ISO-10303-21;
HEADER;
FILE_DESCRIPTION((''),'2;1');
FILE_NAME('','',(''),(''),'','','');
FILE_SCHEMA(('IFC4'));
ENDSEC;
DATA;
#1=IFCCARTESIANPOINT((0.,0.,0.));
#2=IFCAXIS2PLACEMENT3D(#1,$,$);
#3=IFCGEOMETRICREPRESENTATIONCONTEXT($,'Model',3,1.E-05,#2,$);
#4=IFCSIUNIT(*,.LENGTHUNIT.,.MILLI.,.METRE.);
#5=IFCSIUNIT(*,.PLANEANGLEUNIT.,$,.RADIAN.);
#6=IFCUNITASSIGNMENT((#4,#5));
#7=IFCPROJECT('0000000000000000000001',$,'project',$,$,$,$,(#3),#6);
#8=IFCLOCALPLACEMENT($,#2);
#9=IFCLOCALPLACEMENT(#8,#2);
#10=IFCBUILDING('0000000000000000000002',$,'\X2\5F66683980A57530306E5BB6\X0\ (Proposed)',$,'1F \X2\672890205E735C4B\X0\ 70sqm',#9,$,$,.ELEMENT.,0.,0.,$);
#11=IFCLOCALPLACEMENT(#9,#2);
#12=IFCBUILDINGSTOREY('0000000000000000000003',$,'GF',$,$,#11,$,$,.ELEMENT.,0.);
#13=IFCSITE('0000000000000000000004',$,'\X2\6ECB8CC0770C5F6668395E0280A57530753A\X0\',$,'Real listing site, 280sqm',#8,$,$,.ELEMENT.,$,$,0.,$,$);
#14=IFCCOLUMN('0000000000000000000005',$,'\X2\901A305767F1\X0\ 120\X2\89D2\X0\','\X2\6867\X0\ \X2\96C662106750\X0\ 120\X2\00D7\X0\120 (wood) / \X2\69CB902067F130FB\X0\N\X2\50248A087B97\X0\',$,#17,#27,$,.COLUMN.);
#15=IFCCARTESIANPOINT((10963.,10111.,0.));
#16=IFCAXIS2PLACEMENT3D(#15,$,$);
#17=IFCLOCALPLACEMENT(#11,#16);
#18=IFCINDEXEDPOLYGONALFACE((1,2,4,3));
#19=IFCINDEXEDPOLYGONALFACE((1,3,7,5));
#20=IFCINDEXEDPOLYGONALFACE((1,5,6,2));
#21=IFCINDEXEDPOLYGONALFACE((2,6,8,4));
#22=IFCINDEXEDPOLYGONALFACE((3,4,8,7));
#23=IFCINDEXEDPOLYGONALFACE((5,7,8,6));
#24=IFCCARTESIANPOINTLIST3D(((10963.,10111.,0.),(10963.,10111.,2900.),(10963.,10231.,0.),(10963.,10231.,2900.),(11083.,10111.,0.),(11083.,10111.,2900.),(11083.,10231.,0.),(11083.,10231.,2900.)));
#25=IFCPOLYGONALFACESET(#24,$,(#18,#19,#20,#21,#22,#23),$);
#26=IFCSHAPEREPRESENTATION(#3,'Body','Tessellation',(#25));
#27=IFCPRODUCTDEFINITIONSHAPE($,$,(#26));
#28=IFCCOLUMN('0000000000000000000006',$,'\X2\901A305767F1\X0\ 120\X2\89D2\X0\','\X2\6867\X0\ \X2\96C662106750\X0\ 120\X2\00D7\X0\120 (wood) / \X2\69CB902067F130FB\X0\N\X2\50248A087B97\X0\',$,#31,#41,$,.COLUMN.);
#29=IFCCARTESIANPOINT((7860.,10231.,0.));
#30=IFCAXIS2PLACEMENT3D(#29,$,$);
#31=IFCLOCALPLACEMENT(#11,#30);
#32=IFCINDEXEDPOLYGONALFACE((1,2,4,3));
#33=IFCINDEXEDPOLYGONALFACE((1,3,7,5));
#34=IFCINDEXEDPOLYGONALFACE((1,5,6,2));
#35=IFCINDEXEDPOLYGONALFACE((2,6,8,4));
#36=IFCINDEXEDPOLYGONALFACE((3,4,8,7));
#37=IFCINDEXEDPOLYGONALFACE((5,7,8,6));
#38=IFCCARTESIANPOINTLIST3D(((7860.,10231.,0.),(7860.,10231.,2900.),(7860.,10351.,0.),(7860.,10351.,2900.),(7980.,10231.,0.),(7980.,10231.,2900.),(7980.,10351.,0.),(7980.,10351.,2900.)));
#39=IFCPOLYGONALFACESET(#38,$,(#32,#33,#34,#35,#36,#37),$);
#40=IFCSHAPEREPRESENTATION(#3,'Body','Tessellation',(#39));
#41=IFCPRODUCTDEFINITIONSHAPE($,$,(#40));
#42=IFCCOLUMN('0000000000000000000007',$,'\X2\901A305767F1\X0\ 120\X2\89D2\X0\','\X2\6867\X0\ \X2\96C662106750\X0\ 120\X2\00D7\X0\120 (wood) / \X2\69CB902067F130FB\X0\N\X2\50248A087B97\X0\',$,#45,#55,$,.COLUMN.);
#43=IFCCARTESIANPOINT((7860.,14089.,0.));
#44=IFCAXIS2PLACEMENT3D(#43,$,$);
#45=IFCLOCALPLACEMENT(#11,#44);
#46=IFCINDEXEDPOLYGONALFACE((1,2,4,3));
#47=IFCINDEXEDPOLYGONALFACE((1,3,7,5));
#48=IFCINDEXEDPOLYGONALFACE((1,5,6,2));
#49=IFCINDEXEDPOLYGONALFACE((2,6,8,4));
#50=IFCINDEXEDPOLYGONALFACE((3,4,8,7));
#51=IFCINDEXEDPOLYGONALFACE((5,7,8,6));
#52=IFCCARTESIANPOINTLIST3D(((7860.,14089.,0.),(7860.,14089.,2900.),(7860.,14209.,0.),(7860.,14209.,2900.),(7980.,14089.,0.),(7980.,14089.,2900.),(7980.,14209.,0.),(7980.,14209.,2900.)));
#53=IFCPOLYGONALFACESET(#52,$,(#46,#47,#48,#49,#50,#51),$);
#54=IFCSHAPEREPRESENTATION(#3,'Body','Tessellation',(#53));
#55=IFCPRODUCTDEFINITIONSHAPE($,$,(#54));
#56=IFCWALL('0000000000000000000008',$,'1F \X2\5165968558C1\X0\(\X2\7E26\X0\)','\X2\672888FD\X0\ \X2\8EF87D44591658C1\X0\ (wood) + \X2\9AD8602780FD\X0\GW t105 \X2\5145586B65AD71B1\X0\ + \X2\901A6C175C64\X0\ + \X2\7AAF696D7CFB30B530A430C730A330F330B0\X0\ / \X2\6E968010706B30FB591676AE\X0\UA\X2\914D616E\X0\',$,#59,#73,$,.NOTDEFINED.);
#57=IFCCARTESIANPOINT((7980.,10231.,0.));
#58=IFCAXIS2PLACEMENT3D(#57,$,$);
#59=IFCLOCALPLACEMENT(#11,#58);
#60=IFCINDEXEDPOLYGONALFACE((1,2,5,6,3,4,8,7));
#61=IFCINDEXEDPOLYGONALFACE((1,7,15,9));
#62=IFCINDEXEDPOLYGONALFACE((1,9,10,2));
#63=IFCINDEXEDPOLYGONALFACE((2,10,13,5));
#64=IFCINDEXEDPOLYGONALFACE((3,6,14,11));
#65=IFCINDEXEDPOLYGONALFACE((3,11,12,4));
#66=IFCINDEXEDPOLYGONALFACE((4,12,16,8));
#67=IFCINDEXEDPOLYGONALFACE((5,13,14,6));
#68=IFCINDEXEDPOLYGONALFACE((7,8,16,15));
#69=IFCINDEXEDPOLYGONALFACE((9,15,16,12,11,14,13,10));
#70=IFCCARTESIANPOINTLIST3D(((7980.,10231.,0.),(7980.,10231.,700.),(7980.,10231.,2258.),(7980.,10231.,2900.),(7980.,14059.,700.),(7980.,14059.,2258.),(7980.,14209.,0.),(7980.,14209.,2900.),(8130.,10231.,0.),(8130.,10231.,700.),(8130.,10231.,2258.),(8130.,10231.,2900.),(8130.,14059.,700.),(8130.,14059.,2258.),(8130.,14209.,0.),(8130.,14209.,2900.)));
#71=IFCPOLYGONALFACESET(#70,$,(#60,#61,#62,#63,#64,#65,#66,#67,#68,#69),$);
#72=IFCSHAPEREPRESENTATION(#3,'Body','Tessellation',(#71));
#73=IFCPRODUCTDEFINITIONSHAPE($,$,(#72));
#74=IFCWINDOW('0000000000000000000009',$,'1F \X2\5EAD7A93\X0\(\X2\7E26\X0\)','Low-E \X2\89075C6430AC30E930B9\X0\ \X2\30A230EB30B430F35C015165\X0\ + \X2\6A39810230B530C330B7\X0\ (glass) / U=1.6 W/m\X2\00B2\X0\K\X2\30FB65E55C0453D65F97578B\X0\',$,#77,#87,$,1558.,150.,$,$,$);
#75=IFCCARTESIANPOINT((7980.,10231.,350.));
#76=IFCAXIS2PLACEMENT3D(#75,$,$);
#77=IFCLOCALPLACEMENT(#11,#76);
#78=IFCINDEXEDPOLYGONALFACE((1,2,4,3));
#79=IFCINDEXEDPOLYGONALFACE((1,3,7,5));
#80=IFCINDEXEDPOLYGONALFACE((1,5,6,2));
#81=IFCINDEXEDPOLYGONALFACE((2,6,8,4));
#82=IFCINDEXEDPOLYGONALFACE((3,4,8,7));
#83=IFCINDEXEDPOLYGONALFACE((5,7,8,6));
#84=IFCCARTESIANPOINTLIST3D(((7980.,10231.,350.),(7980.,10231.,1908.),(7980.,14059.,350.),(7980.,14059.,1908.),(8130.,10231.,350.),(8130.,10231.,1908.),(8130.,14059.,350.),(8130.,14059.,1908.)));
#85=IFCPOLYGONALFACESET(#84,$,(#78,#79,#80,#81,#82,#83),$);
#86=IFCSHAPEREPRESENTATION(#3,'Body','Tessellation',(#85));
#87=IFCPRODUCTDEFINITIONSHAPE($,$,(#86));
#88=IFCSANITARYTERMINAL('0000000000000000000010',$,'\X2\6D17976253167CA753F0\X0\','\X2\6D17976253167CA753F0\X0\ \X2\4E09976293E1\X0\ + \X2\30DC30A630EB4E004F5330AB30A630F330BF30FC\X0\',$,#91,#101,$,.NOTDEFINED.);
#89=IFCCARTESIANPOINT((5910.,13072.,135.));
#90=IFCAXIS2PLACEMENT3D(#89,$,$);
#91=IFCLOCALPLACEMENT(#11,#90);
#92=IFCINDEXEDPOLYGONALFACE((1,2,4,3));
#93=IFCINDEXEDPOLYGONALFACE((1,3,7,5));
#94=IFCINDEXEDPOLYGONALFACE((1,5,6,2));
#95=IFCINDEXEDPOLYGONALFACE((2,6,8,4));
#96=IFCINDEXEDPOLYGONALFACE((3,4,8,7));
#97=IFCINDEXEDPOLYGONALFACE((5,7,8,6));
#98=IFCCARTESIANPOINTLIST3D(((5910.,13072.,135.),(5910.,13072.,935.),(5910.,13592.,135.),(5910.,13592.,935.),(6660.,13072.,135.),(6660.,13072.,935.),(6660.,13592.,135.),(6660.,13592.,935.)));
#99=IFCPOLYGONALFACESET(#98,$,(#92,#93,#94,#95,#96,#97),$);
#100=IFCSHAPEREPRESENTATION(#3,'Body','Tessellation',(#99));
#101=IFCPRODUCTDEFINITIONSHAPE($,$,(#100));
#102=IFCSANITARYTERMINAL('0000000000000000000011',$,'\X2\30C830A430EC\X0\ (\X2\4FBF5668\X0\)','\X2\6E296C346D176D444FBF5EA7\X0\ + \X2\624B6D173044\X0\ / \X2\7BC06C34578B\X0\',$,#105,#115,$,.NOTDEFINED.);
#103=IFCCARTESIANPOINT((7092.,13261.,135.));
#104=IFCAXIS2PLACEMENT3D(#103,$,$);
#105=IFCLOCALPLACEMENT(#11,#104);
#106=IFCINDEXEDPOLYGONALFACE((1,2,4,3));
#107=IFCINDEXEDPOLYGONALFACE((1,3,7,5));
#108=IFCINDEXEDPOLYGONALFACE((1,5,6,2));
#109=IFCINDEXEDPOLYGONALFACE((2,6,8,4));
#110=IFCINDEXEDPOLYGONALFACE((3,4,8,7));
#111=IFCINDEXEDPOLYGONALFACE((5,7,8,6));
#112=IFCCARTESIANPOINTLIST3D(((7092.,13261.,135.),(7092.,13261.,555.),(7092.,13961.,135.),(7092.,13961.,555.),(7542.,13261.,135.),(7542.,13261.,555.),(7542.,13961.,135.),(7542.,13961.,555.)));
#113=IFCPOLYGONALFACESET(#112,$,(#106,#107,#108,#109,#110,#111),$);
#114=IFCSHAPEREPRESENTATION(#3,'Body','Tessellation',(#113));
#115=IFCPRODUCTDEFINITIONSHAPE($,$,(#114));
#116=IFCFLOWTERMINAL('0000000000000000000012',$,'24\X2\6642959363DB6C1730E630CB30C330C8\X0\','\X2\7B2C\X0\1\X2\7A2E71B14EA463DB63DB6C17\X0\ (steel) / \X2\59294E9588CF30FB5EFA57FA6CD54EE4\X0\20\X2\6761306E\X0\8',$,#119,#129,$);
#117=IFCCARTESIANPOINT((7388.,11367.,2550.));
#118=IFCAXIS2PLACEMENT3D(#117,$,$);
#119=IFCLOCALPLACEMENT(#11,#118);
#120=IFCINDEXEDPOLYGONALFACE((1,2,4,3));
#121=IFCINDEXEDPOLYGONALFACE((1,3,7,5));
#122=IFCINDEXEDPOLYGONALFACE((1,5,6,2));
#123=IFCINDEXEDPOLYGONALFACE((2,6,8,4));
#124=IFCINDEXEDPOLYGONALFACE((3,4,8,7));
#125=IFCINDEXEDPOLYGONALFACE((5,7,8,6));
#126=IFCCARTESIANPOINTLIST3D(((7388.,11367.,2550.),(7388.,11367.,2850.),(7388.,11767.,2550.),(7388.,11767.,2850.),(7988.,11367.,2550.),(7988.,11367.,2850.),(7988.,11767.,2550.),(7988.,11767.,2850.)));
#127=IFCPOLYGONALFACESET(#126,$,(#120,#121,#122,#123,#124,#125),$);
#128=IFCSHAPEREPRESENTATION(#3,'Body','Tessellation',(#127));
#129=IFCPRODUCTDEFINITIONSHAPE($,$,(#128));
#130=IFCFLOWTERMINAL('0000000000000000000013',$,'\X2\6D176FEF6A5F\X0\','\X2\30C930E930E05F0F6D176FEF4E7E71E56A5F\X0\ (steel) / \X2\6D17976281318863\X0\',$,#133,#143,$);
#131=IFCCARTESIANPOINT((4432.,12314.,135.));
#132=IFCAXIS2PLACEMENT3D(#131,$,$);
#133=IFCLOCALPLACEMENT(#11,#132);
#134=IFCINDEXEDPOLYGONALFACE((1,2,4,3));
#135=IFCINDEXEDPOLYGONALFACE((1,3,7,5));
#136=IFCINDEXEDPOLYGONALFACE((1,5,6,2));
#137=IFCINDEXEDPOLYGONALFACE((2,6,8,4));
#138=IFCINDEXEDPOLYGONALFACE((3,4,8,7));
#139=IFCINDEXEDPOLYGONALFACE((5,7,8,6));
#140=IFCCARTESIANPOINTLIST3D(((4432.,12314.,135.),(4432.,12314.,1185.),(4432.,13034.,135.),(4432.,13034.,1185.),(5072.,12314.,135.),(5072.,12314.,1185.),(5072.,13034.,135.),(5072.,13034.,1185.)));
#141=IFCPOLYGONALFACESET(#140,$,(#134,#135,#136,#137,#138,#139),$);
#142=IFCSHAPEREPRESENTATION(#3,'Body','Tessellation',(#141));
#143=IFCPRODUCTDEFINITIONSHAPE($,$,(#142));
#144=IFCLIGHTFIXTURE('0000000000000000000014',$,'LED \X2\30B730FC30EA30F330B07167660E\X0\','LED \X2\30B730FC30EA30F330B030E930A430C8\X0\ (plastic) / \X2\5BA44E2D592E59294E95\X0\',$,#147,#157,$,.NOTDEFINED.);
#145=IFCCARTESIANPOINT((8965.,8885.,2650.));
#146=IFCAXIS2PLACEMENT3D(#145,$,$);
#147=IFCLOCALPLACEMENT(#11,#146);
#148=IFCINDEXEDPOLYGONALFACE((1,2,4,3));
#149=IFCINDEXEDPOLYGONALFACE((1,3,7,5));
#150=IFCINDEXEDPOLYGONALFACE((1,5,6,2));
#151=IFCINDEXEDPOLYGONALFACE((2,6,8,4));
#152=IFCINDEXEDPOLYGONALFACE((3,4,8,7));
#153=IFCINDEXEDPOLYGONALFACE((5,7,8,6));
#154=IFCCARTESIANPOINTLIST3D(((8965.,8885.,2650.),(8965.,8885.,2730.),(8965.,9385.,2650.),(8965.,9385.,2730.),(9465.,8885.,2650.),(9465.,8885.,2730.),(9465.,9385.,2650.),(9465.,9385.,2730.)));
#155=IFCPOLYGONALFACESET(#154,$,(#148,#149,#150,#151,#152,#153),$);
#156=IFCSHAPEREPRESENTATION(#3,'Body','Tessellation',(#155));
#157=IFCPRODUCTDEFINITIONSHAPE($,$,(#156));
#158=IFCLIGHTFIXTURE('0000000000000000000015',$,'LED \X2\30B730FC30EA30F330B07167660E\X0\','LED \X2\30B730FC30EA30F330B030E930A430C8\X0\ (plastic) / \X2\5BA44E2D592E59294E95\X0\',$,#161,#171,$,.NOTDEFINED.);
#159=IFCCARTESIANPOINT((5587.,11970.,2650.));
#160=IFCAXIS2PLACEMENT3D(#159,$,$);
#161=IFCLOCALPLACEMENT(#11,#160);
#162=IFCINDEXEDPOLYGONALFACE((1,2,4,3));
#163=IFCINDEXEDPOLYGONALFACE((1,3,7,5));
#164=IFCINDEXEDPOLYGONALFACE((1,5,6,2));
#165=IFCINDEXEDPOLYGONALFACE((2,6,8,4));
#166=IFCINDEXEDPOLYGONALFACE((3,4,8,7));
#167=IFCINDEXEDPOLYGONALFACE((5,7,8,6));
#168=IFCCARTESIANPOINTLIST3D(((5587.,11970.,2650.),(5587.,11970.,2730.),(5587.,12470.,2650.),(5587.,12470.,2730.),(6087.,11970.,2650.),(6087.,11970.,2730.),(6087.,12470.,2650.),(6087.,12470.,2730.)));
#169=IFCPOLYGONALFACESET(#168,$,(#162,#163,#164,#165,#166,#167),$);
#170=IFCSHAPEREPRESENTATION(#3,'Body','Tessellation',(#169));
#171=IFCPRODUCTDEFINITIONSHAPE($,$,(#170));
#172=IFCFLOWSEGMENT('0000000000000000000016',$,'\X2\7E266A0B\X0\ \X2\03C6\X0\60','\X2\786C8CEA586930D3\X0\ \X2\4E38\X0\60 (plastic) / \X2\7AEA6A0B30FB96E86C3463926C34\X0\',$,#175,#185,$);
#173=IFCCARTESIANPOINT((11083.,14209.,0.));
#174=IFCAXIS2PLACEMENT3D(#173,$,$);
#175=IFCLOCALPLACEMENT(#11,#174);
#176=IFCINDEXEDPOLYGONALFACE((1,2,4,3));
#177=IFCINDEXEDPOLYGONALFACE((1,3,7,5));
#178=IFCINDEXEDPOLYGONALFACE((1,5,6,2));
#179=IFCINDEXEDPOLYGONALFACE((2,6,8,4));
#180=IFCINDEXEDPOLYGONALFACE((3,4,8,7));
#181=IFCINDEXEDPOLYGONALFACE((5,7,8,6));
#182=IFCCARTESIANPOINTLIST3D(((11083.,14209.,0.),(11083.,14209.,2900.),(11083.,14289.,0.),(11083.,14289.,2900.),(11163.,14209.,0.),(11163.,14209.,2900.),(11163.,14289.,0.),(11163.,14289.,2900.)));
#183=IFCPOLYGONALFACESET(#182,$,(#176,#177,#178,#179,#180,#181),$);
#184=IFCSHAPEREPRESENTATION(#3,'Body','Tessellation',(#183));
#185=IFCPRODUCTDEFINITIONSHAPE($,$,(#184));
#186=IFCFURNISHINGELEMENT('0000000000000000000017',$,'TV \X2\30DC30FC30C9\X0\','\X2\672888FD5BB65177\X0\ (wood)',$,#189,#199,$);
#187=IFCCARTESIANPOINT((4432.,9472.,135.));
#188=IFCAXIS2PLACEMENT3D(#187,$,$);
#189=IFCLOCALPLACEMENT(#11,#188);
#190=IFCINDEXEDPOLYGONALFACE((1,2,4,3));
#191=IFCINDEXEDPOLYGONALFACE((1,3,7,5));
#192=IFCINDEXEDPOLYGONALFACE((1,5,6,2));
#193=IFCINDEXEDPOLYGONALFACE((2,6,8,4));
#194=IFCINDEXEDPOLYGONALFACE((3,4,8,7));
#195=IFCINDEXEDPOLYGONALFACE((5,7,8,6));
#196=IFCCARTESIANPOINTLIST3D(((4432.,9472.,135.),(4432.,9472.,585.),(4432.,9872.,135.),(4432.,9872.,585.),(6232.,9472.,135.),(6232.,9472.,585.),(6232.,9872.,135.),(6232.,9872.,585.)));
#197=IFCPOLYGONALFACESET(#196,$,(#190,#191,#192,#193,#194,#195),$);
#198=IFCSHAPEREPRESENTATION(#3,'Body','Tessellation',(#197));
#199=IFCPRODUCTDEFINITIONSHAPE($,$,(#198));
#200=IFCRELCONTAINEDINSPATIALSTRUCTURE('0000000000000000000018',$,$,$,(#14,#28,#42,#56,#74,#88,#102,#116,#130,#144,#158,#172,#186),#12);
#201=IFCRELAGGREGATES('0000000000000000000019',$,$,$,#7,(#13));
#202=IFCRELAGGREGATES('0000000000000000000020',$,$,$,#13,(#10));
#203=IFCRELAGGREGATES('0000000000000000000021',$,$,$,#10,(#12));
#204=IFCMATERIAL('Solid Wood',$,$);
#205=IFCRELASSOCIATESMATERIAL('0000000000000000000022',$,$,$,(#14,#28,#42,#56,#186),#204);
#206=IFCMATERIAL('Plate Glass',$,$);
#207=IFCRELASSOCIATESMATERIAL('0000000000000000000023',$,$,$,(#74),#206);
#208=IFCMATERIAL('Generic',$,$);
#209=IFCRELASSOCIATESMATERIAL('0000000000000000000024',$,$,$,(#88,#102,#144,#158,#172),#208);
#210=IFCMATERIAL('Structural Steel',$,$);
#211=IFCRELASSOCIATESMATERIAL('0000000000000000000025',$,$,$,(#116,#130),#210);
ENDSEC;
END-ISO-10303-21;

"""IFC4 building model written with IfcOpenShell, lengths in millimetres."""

from ifc_helpers import new_model, si_unit, frame, frame_2d, origin, place, context, project, spatial, rectangle, extrude, material, element, fill, save


model = new_model("IFC4")

# Units and contexts
model_context = context("Model", 3, precision=1e-05, world=origin())
ifc_project = project(units=[si_unit("LENGTHUNIT", "METRE", prefix="MILLI"), si_unit("PLANEANGLEUNIT", "RADIAN")], contexts=[model_context])

# Site, building, storey
site_placement = place(None, origin())
site = spatial("IfcSite", under=ifc_project, at=site_placement, Name="滋賀県彦根市肥田町", ObjectType="Real listing site, 280sqm", CompositionType="ELEMENT", RefElevation=0.0)
building_placement = place(site_placement, origin())
building = spatial("IfcBuilding", under=site, at=building_placement, Name="彦根肥田の家 (Proposed)", ObjectType="1F 木造平屋 70sqm", CompositionType="ELEMENT", ElevationOfRefHeight=0.0, ElevationOfTerrain=0.0)
storey_placement = place(building_placement, origin())
storey = spatial("IfcBuildingStorey", under=building, at=storey_placement, Name="GF", CompositionType="ELEMENT", Elevation=0.0)

# Columns
ifc_material_1 = material(Name="Solid Wood")
column_1_placement = place(storey_placement, frame((10963.0, 10111.0, 0.0)))
element("IfcColumn", 1, at=column_1_placement, inside=storey, material=ifc_material_1, Name="通し柱 120角", Description="桧 集成材 120×120 (wood) / 構造柱・N値計算", PredefinedType="COLUMN", context=model_context, shape_type="SweptSolid", body=[
    extrude(rectangle(XDim=120.0, YDim=120.0, at=frame_2d((60.0, 60.0))), frame((10963.0, 10111.0, 0.0)), (0.0, 0.0, 1.0), 2900.0),
])
column_2_placement = place(storey_placement, frame((7860.0, 10231.0, 0.0)))
element("IfcColumn", 2, at=column_2_placement, inside=storey, material=ifc_material_1, Name="通し柱 120角", Description="桧 集成材 120×120 (wood) / 構造柱・N値計算", PredefinedType="COLUMN", context=model_context, shape_type="SweptSolid", body=[
    extrude(rectangle(XDim=120.0, YDim=120.0, at=frame_2d((60.0, 60.0))), frame((7860.0, 10231.0, 0.0)), (0.0, 0.0, 1.0), 2900.0),
])
column_3_placement = place(storey_placement, frame((7860.0, 14089.0, 0.0)))
element("IfcColumn", 3, at=column_3_placement, inside=storey, material=ifc_material_1, Name="通し柱 120角", Description="桧 集成材 120×120 (wood) / 構造柱・N値計算", PredefinedType="COLUMN", context=model_context, shape_type="SweptSolid", body=[
    extrude(rectangle(XDim=120.0, YDim=120.0, at=frame_2d((60.0, 60.0))), frame((7860.0, 14089.0, 0.0)), (0.0, 0.0, 1.0), 2900.0),
])

# Wall, opening, window
wall_1_placement = place(storey_placement, frame((7980.0, 10231.0, 0.0)))
wall_1 = element("IfcWall", 4, at=wall_1_placement, inside=storey, material=ifc_material_1, Name="1F 入隅壁(縦)", Description="木製 軸組外壁 (wood) + 高性能GW t105 充填断熱 + 通気層 + 窯業系サイディング / 準耐火・外皮UA配慮", PredefinedType="NOTDEFINED", context=model_context, shape_type="SweptSolid", body=[
    extrude(rectangle(XDim=150.0, YDim=3978.0, at=frame_2d((75.0, 1989.0))), frame((7980.0, 10231.0, 0.0)), (0.0, 0.0, 1.0), 2900.0),
])
opening_placement = place(storey_placement, frame((7980.0, 10231.0, 350.0)))
opening = element("IfcOpeningElement", 5, at=opening_placement, cuts=wall_1, PredefinedType="NOTDEFINED", context=model_context, shape_type="SweptSolid", body=[
    extrude(rectangle(XDim=150.0, YDim=3828.0, at=frame_2d((75.0, 1914.0))), frame((7980.0, 10231.0, 350.0)), (0.0, 0.0, 1.0), 1558.0),
])
ifc_material_2 = material(Name="Plate Glass")
window_placement = place(storey_placement, frame((7980.0, 10231.0, 350.0)))
window = element("IfcWindow", 6, at=window_placement, inside=storey, material=ifc_material_2, Name="1F 庭窓(縦)", Description="Low-E 複層ガラス アルゴン封入 + 樹脂サッシ (glass) / U=1.6 W/m²K・日射取得型", OverallHeight=1558.0, OverallWidth=150.0, context=model_context, shape_type="SweptSolid", body=[
    extrude(rectangle(XDim=150.0, YDim=3828.0, at=frame_2d((75.0, 1914.0))), frame((7980.0, 10231.0, 350.0)), (0.0, 0.0, 1.0), 1558.0),
])
fill(opening, window)

# Sanitary terminals
ifc_material_3 = material(Name="Generic")
sanitary_terminal_1_placement = place(storey_placement, frame((5910.0, 13072.0, 135.0)))
element("IfcSanitaryTerminal", 7, at=sanitary_terminal_1_placement, inside=storey, material=ifc_material_3, Name="洗面化粧台", Description="洗面化粧台 三面鏡 + ボウル一体カウンター", PredefinedType="NOTDEFINED", context=model_context, shape_type="SweptSolid", body=[
    extrude(rectangle(XDim=750.0, YDim=520.0, at=frame_2d((375.0, 260.0))), frame((5910.0, 13072.0, 135.0)), (0.0, 0.0, 1.0), 800.0),
])
sanitary_terminal_2_placement = place(storey_placement, frame((7092.0, 13261.0, 135.0)))
element("IfcSanitaryTerminal", 8, at=sanitary_terminal_2_placement, inside=storey, material=ifc_material_3, Name="トイレ (便器)", Description="温水洗浄便座 + 手洗い / 節水型", PredefinedType="NOTDEFINED", context=model_context, shape_type="SweptSolid", body=[
    extrude(rectangle(XDim=450.0, YDim=700.0, at=frame_2d((225.0, 350.0))), frame((7092.0, 13261.0, 135.0)), (0.0, 0.0, 1.0), 420.0),
])

# Flow terminals
ifc_material_4 = material(Name="Structural Steel")
flow_terminal_1_placement = place(storey_placement, frame((7388.0, 11367.0, 2550.0)))
element("IfcFlowTerminal", 9, at=flow_terminal_1_placement, inside=storey, material=ifc_material_4, Name="24時間換気ユニット", Description="第1種熱交換換気 (steel) / 天井裏・建基法令20条の8", context=model_context, shape_type="SweptSolid", body=[
    extrude(rectangle(XDim=600.0, YDim=400.0, at=frame_2d((300.0, 200.0))), frame((7388.0, 11367.0, 2550.0)), (0.0, 0.0, 1.0), 300.0),
])
flow_terminal_2_placement = place(storey_placement, frame((4432.0, 12314.0, 135.0)))
element("IfcFlowTerminal", 10, at=flow_terminal_2_placement, inside=storey, material=ifc_material_4, Name="洗濯機", Description="ドラム式洗濯乾燥機 (steel) / 洗面脱衣", context=model_context, shape_type="SweptSolid", body=[
    extrude(rectangle(XDim=640.0, YDim=720.0, at=frame_2d((320.0, 360.0))), frame((4432.0, 12314.0, 135.0)), (0.0, 0.0, 1.0), 1050.0),
])

# Light fixtures
light_fixture_1_placement = place(storey_placement, frame((8965.0, 8885.0, 2650.0)))
element("IfcLightFixture", 11, at=light_fixture_1_placement, inside=storey, material=ifc_material_3, Name="LED シーリング照明", Description="LED シーリングライト (plastic) / 室中央天井", PredefinedType="NOTDEFINED", context=model_context, shape_type="SweptSolid", body=[
    extrude(rectangle(XDim=500.0, YDim=500.0, at=frame_2d((250.0, 250.0))), frame((8965.0, 8885.0, 2650.0)), (0.0, 0.0, 1.0), 80.0),
])
light_fixture_2_placement = place(storey_placement, frame((5587.0, 11970.0, 2650.0)))
element("IfcLightFixture", 12, at=light_fixture_2_placement, inside=storey, material=ifc_material_3, Name="LED シーリング照明", Description="LED シーリングライト (plastic) / 室中央天井", PredefinedType="NOTDEFINED", context=model_context, shape_type="SweptSolid", body=[
    extrude(rectangle(XDim=500.0, YDim=500.0, at=frame_2d((250.0, 250.0))), frame((5587.0, 11970.0, 2650.0)), (0.0, 0.0, 1.0), 80.0),
])

# Flow segment
flow_segment_placement = place(storey_placement, frame((11083.0, 14209.0, 0.0)))
element("IfcFlowSegment", 13, at=flow_segment_placement, inside=storey, material=ifc_material_3, Name="縦樋 φ60", Description="硬質塩ビ 丸60 (plastic) / 竪樋・雨水排水", context=model_context, shape_type="SweptSolid", body=[
    extrude(rectangle(XDim=80.0, YDim=80.0, at=frame_2d((40.0, 40.0))), frame((11083.0, 14209.0, 0.0)), (0.0, 0.0, 1.0), 2900.0),
])

# Furnishing element
furnishing_placement = place(storey_placement, frame((4432.0, 9472.0, 135.0)))
element("IfcFurnishingElement", 14, at=furnishing_placement, inside=storey, material=ifc_material_1, Name="TV ボード", Description="木製家具 (wood)", context=model_context, shape_type="SweptSolid", body=[
    extrude(rectangle(XDim=1800.0, YDim=400.0, at=frame_2d((900.0, 200.0))), frame((4432.0, 9472.0, 135.0)), (0.0, 0.0, 1.0), 450.0),
])

save(model, "model.ifc")
